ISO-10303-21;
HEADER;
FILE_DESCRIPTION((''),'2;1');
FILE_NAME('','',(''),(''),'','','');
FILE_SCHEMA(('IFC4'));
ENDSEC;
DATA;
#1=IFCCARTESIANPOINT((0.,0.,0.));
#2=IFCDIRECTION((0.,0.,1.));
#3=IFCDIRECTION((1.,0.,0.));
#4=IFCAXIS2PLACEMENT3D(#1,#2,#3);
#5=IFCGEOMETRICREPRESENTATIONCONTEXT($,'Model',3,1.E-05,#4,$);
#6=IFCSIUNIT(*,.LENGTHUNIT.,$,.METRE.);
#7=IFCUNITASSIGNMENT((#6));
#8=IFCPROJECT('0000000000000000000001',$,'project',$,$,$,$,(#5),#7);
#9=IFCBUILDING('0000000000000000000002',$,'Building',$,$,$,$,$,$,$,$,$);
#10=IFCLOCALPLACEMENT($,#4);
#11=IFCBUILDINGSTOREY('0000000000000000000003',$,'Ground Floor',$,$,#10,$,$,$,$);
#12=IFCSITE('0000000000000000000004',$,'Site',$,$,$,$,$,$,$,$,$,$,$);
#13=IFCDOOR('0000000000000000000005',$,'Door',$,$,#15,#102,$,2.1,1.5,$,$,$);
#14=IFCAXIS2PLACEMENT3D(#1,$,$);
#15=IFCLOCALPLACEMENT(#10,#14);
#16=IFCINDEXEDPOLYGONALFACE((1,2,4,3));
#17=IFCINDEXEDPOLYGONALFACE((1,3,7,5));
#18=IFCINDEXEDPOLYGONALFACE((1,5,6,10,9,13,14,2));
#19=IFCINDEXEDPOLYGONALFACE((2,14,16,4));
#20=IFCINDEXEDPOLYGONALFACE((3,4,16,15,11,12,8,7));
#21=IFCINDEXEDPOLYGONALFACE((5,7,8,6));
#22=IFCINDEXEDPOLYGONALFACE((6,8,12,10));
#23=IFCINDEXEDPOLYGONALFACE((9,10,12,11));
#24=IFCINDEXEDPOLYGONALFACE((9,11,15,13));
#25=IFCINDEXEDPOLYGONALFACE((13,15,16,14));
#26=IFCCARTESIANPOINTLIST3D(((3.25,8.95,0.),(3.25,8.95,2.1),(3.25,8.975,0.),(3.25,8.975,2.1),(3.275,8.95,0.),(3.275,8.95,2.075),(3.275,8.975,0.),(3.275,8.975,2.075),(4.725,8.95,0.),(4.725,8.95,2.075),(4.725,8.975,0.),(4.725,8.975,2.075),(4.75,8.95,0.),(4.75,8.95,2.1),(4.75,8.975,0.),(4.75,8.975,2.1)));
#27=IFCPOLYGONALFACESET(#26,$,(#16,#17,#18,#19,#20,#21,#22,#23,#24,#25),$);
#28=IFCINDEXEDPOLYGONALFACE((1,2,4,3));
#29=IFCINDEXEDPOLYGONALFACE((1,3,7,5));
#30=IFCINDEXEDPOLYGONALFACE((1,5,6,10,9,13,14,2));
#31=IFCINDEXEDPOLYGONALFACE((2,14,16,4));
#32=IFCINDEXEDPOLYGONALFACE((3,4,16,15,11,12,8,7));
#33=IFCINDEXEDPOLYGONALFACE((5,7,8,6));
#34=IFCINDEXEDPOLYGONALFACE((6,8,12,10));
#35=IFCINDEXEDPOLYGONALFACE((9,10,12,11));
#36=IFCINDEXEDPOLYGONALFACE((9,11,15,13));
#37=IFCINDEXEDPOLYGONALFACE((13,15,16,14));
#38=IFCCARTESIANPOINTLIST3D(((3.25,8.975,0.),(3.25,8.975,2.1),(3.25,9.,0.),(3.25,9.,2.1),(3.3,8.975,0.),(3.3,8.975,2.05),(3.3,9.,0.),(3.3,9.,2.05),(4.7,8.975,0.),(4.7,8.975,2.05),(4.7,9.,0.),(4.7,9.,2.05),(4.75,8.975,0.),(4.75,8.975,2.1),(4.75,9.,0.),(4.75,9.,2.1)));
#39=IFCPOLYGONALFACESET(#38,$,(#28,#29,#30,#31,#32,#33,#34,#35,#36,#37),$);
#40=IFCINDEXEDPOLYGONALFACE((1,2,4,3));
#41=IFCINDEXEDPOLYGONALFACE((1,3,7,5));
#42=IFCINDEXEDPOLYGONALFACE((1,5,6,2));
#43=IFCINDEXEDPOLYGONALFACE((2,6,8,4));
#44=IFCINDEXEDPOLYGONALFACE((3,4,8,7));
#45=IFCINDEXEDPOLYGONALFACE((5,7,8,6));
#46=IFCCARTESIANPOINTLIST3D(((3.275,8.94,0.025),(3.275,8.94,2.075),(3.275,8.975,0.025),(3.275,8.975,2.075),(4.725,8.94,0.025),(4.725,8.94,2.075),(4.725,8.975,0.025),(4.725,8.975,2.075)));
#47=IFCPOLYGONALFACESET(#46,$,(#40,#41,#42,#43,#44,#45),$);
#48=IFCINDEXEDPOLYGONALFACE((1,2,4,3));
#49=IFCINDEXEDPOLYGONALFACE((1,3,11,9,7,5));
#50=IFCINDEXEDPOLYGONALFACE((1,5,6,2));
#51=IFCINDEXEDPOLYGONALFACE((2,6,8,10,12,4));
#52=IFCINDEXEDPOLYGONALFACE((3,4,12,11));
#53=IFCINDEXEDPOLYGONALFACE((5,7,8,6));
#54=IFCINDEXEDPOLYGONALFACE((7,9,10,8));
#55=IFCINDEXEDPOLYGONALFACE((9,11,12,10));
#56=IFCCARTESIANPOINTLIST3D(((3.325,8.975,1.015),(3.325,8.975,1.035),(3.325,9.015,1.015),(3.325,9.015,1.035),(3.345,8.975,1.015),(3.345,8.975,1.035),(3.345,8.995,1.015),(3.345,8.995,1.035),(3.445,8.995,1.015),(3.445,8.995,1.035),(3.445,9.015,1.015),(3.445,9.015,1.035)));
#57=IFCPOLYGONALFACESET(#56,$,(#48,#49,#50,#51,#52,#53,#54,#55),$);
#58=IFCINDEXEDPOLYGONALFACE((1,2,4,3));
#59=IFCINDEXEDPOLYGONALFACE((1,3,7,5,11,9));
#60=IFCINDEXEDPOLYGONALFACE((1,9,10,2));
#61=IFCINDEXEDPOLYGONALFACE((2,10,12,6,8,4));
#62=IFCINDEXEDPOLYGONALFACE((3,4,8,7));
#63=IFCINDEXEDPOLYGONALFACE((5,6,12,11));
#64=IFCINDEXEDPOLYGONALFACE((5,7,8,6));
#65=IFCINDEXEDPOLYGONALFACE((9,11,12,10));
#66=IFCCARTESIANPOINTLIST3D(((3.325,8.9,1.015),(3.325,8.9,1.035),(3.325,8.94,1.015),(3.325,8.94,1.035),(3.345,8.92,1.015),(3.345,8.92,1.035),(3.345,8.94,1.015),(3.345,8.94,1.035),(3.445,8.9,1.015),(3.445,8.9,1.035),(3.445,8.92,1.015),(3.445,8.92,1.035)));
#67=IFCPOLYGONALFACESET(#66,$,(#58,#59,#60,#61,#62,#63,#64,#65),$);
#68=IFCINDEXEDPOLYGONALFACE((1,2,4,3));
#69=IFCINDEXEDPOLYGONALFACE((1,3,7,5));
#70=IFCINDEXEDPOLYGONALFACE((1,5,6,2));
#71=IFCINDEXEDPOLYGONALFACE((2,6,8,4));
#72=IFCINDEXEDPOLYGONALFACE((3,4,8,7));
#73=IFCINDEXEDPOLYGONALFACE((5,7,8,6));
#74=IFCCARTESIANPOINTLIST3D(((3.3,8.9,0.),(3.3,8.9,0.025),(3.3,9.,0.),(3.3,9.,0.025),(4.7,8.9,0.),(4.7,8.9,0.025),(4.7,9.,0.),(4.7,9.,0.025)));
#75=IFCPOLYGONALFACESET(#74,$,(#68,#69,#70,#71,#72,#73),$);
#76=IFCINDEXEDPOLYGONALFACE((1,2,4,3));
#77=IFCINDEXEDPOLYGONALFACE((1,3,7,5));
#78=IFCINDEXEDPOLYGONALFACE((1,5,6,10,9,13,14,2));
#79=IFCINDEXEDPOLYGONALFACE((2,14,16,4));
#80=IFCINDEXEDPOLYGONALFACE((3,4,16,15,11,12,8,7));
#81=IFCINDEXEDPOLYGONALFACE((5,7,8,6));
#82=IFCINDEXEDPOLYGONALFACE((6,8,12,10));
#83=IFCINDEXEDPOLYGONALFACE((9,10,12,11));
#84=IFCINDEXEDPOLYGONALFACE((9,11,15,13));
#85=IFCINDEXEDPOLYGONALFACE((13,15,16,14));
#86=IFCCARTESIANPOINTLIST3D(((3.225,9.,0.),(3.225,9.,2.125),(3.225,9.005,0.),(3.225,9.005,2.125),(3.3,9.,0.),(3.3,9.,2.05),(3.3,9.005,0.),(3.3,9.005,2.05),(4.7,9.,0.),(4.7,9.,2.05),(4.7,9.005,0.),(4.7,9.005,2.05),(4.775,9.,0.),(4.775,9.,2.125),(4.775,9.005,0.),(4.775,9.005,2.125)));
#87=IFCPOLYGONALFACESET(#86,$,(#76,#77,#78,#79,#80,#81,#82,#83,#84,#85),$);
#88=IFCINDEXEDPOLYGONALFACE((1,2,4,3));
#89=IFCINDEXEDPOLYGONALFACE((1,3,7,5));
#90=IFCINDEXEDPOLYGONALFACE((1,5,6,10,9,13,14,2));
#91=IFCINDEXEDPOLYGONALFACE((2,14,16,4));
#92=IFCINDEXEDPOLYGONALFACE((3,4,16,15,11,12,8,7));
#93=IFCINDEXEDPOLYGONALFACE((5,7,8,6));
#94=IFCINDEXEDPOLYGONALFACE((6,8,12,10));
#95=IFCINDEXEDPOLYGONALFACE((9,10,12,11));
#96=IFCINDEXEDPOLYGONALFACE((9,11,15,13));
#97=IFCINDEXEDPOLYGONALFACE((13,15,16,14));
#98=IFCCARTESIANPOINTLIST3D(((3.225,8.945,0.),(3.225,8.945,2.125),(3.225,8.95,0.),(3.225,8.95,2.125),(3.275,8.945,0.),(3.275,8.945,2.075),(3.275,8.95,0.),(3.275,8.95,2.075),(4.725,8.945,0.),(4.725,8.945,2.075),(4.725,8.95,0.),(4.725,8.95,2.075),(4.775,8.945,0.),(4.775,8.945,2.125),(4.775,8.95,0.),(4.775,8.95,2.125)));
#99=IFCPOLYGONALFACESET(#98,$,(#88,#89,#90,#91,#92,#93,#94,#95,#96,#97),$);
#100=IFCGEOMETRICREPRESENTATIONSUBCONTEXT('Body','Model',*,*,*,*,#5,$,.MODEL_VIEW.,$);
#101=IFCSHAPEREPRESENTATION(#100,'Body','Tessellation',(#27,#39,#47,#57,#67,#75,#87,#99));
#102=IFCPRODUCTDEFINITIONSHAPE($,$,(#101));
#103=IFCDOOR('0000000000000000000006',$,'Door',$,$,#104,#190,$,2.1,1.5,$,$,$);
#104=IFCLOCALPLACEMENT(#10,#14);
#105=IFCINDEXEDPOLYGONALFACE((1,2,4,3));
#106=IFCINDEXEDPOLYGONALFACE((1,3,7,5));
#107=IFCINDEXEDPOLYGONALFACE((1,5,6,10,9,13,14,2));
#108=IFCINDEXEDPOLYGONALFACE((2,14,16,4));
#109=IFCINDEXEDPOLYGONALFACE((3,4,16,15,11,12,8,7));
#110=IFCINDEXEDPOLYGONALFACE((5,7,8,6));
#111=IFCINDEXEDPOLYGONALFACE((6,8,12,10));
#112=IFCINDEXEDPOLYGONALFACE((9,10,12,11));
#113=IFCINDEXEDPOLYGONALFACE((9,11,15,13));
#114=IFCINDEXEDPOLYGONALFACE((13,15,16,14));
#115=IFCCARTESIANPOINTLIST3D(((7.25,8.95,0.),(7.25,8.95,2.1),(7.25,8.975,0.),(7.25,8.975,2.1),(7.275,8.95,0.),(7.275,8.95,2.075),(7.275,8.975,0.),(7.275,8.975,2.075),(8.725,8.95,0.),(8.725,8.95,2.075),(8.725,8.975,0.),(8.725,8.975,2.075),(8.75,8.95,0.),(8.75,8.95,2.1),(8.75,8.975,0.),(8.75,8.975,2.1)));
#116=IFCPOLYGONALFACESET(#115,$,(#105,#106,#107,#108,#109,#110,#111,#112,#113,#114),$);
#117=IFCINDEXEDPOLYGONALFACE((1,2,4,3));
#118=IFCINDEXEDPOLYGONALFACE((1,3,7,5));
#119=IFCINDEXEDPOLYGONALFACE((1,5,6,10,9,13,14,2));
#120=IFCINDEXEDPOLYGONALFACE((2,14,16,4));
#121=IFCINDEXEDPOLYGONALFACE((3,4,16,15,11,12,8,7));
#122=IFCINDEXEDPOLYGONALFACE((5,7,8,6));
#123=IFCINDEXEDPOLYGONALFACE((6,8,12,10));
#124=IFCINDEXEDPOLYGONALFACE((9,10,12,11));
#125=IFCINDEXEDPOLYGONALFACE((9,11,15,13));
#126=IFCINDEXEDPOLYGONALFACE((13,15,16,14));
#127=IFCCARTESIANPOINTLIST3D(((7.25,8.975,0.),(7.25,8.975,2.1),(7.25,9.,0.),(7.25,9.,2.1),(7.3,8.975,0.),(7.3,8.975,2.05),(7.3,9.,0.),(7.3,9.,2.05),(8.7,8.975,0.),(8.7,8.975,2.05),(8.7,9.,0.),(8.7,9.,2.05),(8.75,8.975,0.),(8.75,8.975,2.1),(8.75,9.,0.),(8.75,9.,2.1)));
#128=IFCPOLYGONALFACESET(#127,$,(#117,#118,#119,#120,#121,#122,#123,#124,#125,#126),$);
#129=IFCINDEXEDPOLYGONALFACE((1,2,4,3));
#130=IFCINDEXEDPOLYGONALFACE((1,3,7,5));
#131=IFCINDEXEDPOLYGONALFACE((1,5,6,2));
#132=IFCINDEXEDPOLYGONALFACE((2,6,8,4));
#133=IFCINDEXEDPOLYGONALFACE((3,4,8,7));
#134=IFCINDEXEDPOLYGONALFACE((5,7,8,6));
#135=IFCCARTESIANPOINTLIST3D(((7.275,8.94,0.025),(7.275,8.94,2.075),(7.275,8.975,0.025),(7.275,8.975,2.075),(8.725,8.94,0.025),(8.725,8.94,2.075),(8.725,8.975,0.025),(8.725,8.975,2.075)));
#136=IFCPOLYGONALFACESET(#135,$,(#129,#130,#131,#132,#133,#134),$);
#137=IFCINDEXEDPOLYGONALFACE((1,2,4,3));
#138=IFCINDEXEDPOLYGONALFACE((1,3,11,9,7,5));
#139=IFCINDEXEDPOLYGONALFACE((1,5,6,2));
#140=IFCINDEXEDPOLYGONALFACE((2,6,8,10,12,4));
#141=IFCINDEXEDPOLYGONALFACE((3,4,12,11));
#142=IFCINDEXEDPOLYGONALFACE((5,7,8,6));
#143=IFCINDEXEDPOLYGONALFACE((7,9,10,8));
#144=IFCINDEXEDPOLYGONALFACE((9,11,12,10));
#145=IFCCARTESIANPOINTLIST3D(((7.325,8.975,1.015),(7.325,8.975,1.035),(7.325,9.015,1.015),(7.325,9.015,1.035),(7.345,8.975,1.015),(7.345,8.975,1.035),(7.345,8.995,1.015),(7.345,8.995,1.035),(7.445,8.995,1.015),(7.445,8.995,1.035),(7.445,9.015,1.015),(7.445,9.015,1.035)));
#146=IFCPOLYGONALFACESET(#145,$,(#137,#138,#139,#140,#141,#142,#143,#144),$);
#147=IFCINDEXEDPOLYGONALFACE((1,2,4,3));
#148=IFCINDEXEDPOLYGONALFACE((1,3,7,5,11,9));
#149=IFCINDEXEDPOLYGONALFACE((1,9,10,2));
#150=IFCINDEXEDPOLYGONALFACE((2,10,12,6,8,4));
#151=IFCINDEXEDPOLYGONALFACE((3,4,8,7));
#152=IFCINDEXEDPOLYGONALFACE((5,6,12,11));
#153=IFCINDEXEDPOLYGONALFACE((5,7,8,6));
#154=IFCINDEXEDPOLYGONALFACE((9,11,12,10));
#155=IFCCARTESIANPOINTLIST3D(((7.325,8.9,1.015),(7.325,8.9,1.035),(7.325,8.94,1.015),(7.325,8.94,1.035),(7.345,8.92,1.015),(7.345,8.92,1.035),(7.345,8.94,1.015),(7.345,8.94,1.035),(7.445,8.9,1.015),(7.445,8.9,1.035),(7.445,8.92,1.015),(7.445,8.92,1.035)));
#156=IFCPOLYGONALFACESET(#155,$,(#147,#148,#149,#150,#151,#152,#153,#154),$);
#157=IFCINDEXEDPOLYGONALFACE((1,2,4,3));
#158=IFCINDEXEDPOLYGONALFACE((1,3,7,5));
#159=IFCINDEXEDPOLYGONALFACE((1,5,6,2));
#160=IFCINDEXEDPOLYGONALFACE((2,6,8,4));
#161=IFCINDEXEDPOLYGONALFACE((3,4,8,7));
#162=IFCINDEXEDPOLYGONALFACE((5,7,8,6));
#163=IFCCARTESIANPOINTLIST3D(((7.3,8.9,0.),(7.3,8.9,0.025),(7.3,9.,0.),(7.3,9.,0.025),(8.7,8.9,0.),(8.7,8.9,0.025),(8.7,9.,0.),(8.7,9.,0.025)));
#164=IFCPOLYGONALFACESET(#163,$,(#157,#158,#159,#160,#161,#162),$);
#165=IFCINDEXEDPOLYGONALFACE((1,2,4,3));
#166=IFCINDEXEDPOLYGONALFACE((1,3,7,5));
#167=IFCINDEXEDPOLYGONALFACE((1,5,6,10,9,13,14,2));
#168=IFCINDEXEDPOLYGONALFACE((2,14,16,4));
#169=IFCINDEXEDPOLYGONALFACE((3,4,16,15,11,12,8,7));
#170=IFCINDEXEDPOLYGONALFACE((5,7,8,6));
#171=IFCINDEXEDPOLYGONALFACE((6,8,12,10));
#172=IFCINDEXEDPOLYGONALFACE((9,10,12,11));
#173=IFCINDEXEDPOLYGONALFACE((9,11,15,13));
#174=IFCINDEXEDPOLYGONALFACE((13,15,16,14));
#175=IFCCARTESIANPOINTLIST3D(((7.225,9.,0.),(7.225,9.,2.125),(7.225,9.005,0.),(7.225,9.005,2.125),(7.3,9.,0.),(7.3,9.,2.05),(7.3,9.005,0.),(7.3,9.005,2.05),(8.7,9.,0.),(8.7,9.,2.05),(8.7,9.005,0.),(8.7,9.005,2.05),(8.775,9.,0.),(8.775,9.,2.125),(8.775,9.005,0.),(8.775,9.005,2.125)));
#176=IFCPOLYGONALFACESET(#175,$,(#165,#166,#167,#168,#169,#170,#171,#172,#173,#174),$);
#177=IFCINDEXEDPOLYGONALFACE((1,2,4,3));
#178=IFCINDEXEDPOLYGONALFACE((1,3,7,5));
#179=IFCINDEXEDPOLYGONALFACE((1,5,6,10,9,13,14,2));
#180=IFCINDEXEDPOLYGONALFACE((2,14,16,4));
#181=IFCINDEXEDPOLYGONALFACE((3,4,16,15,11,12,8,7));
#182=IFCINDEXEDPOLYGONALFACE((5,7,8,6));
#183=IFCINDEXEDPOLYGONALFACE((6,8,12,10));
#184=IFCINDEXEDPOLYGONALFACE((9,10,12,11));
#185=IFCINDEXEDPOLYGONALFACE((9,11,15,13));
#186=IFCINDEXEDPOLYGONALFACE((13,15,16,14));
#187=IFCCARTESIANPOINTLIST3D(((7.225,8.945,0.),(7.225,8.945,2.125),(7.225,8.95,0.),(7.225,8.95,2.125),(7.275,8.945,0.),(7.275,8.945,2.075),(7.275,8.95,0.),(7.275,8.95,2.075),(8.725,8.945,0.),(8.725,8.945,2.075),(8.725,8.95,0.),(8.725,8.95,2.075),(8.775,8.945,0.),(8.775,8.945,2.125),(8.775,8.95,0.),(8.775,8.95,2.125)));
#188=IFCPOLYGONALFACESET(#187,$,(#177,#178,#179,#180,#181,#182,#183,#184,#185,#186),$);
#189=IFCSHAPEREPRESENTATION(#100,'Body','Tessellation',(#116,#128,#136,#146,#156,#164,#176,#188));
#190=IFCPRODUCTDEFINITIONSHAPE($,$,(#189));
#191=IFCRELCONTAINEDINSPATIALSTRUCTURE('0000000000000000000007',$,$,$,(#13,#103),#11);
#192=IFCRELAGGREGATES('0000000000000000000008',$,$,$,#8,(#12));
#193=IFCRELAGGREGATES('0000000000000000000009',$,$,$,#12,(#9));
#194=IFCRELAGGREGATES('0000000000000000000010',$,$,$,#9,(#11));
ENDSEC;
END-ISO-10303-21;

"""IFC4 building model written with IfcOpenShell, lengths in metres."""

from ifc_helpers import new_model, si_unit, frame, origin_with_axes, place, context, subcontext, project, spatial, line, indexed_curve, outline, extrude, element, save


model = new_model("IFC4")

# Units and contexts
model_context = context("Model", 3, precision=1e-05, world=origin_with_axes())
body_context = subcontext(model_context, "Body", "Model", "MODEL_VIEW")
ifc_project = project(units=[si_unit("LENGTHUNIT", "METRE")], contexts=[model_context])

# Site, building, storey
site = spatial("IfcSite", under=ifc_project, Name="Site")
building = spatial("IfcBuilding", under=site, Name="Building")
storey_placement = place(None, origin_with_axes())
storey = spatial("IfcBuildingStorey", under=building, at=storey_placement, Name="Ground Floor")

# Doors
door_1_placement = place(storey_placement, frame((4.75, 9.0, 0.0), z_axis=(0.0, 0.0, 1.0), x_axis=(-1.0, 0.0, 0.0)))
element("IfcDoor", 1, at=door_1_placement, inside=storey, Name="Door", OverallHeight=2.1, OverallWidth=1.5, context=body_context, shape_type="SweptSolid", body=[
    extrude(outline(indexed_curve([(0.0, 0.0), (0.0, 2.1), (1.5, 2.1), (1.5, 0.0), (1.475, 0.0), (1.475, 2.075), (0.025, 2.075), (0.025, 0.0)], segments=[line(1, 2, 3, 4, 5, 6, 7, 8, 1)])), frame((0.0, 0.025, 0.0), z_axis=(0.0, -1.0, 0.0), x_axis=(1.0, 0.0, 0.0)), (0.0, 0.0, -1.0), 0.025),
    extrude(outline(indexed_curve([(0.0, 0.0), (0.0, 2.1), (1.5, 2.1), (1.5, 0.0), (1.45, 0.0), (1.45, 2.05), (0.05, 2.05), (0.05, 0.0)], segments=[line(1, 2, 3, 4, 5, 6, 7, 8, 1)])), frame((0.0, 0.0, 0.0), z_axis=(0.0, -1.0, 0.0), x_axis=(1.0, 0.0, 0.0)), (0.0, 0.0, -1.0), 0.025),
    extrude(outline(indexed_curve([(0.0, 0.0), (1.45, 0.0), (1.45, 0.035), (0.0, 0.035)], segments=[line(1, 2, 3, 4, 1)])), frame((0.025, 0.025, 0.025), z_axis=(0.0, 0.0, 1.0), x_axis=(1.0, 0.0, 0.0)), (0.0, 0.0, 1.0), 2.05),
    extrude(outline(indexed_curve([(0.0, 0.0), (0.0, -0.04), (-0.12, -0.04), (-0.12, -0.02), (-0.02, -0.02), (-0.02, 0.0)], segments=[line(1, 2, 3, 4, 5, 6, 1)])), frame((1.425, 0.025, 1.015), z_axis=(0.0, 0.0, 1.0), x_axis=(1.0, 0.0, 0.0)), (0.0, 0.0, 1.0), 0.02),
    extrude(outline(indexed_curve([(0.0, 0.0), (0.0, 0.04), (-0.12, 0.04), (-0.12, 0.02), (-0.02, 0.02), (-0.02, 0.0)], segments=[line(1, 2, 3, 4, 5, 6, 1)])), frame((1.425, 0.06, 1.015), z_axis=(0.0, 0.0, 1.0), x_axis=(1.0, 0.0, 0.0)), (0.0, 0.0, 1.0), 0.02),
    extrude(outline(indexed_curve([(0.0, 0.0), (1.4, 0.0), (1.4, 0.1), (0.0, 0.1)], segments=[line(1, 2, 3, 4, 1)])), frame((0.05, 0.0, 0.0), z_axis=(0.0, 0.0, 1.0), x_axis=(1.0, 0.0, 0.0)), (0.0, 0.0, 1.0), 0.025),
    extrude(outline(indexed_curve([(0.0, 0.0), (0.0, 2.125), (1.55, 2.125), (1.55, 0.0), (1.475, 0.0), (1.475, 2.05), (0.075, 2.05), (0.075, 0.0)], segments=[line(1, 2, 3, 4, 5, 6, 7, 8, 1)])), frame((-0.025, -0.005, 0.0), z_axis=(0.0, -1.0, 0.0), x_axis=(1.0, 0.0, 0.0)), (0.0, 0.0, -1.0), 0.005),
    extrude(outline(indexed_curve([(0.0, 0.0), (0.0, 2.125), (1.55, 2.125), (1.55, 0.0), (1.5, 0.0), (1.5, 2.075), (0.05, 2.075), (0.05, 0.0)], segments=[line(1, 2, 3, 4, 5, 6, 7, 8, 1)])), frame((-0.025, 0.05, 0.0), z_axis=(0.0, -1.0, 0.0), x_axis=(1.0, 0.0, 0.0)), (0.0, 0.0, -1.0), 0.005),
])
door_2_placement = place(storey_placement, frame((8.75, 9.0, 0.0), z_axis=(0.0, 0.0, 1.0), x_axis=(-1.0, 0.0, 0.0)))
element("IfcDoor", 2, at=door_2_placement, inside=storey, Name="Door", OverallHeight=2.1, OverallWidth=1.5, context=body_context, shape_type="SweptSolid", body=[
    extrude(outline(indexed_curve([(0.0, 0.0), (0.0, 2.1), (1.5, 2.1), (1.5, 0.0), (1.475, 0.0), (1.475, 2.075), (0.025, 2.075), (0.025, 0.0)], segments=[line(1, 2, 3, 4, 5, 6, 7, 8, 1)])), frame((0.0, 0.025, 0.0), z_axis=(0.0, -1.0, 0.0), x_axis=(1.0, 0.0, 0.0)), (0.0, 0.0, -1.0), 0.025),
    extrude(outline(indexed_curve([(0.0, 0.0), (0.0, 2.1), (1.5, 2.1), (1.5, 0.0), (1.45, 0.0), (1.45, 2.05), (0.05, 2.05), (0.05, 0.0)], segments=[line(1, 2, 3, 4, 5, 6, 7, 8, 1)])), frame((0.0, 0.0, 0.0), z_axis=(0.0, -1.0, 0.0), x_axis=(1.0, 0.0, 0.0)), (0.0, 0.0, -1.0), 0.025),
    extrude(outline(indexed_curve([(0.0, 0.0), (1.45, 0.0), (1.45, 0.035), (0.0, 0.035)], segments=[line(1, 2, 3, 4, 1)])), frame((0.025, 0.025, 0.025), z_axis=(0.0, 0.0, 1.0), x_axis=(1.0, 0.0, 0.0)), (0.0, 0.0, 1.0), 2.05),
    extrude(outline(indexed_curve([(0.0, 0.0), (0.0, -0.04), (-0.12, -0.04), (-0.12, -0.02), (-0.02, -0.02), (-0.02, 0.0)], segments=[line(1, 2, 3, 4, 5, 6, 1)])), frame((1.425, 0.025, 1.015), z_axis=(0.0, 0.0, 1.0), x_axis=(1.0, 0.0, 0.0)), (0.0, 0.0, 1.0), 0.02),
    extrude(outline(indexed_curve([(0.0, 0.0), (0.0, 0.04), (-0.12, 0.04), (-0.12, 0.02), (-0.02, 0.02), (-0.02, 0.0)], segments=[line(1, 2, 3, 4, 5, 6, 1)])), frame((1.425, 0.06, 1.015), z_axis=(0.0, 0.0, 1.0), x_axis=(1.0, 0.0, 0.0)), (0.0, 0.0, 1.0), 0.02),
    extrude(outline(indexed_curve([(0.0, 0.0), (1.4, 0.0), (1.4, 0.1), (0.0, 0.1)], segments=[line(1, 2, 3, 4, 1)])), frame((0.05, 0.0, 0.0), z_axis=(0.0, 0.0, 1.0), x_axis=(1.0, 0.0, 0.0)), (0.0, 0.0, 1.0), 0.025),
    extrude(outline(indexed_curve([(0.0, 0.0), (0.0, 2.125), (1.55, 2.125), (1.55, 0.0), (1.475, 0.0), (1.475, 2.05), (0.075, 2.05), (0.075, 0.0)], segments=[line(1, 2, 3, 4, 5, 6, 7, 8, 1)])), frame((-0.025, -0.005, 0.0), z_axis=(0.0, -1.0, 0.0), x_axis=(1.0, 0.0, 0.0)), (0.0, 0.0, -1.0), 0.005),
    extrude(outline(indexed_curve([(0.0, 0.0), (0.0, 2.125), (1.55, 2.125), (1.55, 0.0), (1.5, 0.0), (1.5, 2.075), (0.05, 2.075), (0.05, 0.0)], segments=[line(1, 2, 3, 4, 5, 6, 7, 8, 1)])), frame((-0.025, 0.05, 0.0), z_axis=(0.0, -1.0, 0.0), x_axis=(1.0, 0.0, 0.0)), (0.0, 0.0, -1.0), 0.005),
])

save(model, "model.ifc")
